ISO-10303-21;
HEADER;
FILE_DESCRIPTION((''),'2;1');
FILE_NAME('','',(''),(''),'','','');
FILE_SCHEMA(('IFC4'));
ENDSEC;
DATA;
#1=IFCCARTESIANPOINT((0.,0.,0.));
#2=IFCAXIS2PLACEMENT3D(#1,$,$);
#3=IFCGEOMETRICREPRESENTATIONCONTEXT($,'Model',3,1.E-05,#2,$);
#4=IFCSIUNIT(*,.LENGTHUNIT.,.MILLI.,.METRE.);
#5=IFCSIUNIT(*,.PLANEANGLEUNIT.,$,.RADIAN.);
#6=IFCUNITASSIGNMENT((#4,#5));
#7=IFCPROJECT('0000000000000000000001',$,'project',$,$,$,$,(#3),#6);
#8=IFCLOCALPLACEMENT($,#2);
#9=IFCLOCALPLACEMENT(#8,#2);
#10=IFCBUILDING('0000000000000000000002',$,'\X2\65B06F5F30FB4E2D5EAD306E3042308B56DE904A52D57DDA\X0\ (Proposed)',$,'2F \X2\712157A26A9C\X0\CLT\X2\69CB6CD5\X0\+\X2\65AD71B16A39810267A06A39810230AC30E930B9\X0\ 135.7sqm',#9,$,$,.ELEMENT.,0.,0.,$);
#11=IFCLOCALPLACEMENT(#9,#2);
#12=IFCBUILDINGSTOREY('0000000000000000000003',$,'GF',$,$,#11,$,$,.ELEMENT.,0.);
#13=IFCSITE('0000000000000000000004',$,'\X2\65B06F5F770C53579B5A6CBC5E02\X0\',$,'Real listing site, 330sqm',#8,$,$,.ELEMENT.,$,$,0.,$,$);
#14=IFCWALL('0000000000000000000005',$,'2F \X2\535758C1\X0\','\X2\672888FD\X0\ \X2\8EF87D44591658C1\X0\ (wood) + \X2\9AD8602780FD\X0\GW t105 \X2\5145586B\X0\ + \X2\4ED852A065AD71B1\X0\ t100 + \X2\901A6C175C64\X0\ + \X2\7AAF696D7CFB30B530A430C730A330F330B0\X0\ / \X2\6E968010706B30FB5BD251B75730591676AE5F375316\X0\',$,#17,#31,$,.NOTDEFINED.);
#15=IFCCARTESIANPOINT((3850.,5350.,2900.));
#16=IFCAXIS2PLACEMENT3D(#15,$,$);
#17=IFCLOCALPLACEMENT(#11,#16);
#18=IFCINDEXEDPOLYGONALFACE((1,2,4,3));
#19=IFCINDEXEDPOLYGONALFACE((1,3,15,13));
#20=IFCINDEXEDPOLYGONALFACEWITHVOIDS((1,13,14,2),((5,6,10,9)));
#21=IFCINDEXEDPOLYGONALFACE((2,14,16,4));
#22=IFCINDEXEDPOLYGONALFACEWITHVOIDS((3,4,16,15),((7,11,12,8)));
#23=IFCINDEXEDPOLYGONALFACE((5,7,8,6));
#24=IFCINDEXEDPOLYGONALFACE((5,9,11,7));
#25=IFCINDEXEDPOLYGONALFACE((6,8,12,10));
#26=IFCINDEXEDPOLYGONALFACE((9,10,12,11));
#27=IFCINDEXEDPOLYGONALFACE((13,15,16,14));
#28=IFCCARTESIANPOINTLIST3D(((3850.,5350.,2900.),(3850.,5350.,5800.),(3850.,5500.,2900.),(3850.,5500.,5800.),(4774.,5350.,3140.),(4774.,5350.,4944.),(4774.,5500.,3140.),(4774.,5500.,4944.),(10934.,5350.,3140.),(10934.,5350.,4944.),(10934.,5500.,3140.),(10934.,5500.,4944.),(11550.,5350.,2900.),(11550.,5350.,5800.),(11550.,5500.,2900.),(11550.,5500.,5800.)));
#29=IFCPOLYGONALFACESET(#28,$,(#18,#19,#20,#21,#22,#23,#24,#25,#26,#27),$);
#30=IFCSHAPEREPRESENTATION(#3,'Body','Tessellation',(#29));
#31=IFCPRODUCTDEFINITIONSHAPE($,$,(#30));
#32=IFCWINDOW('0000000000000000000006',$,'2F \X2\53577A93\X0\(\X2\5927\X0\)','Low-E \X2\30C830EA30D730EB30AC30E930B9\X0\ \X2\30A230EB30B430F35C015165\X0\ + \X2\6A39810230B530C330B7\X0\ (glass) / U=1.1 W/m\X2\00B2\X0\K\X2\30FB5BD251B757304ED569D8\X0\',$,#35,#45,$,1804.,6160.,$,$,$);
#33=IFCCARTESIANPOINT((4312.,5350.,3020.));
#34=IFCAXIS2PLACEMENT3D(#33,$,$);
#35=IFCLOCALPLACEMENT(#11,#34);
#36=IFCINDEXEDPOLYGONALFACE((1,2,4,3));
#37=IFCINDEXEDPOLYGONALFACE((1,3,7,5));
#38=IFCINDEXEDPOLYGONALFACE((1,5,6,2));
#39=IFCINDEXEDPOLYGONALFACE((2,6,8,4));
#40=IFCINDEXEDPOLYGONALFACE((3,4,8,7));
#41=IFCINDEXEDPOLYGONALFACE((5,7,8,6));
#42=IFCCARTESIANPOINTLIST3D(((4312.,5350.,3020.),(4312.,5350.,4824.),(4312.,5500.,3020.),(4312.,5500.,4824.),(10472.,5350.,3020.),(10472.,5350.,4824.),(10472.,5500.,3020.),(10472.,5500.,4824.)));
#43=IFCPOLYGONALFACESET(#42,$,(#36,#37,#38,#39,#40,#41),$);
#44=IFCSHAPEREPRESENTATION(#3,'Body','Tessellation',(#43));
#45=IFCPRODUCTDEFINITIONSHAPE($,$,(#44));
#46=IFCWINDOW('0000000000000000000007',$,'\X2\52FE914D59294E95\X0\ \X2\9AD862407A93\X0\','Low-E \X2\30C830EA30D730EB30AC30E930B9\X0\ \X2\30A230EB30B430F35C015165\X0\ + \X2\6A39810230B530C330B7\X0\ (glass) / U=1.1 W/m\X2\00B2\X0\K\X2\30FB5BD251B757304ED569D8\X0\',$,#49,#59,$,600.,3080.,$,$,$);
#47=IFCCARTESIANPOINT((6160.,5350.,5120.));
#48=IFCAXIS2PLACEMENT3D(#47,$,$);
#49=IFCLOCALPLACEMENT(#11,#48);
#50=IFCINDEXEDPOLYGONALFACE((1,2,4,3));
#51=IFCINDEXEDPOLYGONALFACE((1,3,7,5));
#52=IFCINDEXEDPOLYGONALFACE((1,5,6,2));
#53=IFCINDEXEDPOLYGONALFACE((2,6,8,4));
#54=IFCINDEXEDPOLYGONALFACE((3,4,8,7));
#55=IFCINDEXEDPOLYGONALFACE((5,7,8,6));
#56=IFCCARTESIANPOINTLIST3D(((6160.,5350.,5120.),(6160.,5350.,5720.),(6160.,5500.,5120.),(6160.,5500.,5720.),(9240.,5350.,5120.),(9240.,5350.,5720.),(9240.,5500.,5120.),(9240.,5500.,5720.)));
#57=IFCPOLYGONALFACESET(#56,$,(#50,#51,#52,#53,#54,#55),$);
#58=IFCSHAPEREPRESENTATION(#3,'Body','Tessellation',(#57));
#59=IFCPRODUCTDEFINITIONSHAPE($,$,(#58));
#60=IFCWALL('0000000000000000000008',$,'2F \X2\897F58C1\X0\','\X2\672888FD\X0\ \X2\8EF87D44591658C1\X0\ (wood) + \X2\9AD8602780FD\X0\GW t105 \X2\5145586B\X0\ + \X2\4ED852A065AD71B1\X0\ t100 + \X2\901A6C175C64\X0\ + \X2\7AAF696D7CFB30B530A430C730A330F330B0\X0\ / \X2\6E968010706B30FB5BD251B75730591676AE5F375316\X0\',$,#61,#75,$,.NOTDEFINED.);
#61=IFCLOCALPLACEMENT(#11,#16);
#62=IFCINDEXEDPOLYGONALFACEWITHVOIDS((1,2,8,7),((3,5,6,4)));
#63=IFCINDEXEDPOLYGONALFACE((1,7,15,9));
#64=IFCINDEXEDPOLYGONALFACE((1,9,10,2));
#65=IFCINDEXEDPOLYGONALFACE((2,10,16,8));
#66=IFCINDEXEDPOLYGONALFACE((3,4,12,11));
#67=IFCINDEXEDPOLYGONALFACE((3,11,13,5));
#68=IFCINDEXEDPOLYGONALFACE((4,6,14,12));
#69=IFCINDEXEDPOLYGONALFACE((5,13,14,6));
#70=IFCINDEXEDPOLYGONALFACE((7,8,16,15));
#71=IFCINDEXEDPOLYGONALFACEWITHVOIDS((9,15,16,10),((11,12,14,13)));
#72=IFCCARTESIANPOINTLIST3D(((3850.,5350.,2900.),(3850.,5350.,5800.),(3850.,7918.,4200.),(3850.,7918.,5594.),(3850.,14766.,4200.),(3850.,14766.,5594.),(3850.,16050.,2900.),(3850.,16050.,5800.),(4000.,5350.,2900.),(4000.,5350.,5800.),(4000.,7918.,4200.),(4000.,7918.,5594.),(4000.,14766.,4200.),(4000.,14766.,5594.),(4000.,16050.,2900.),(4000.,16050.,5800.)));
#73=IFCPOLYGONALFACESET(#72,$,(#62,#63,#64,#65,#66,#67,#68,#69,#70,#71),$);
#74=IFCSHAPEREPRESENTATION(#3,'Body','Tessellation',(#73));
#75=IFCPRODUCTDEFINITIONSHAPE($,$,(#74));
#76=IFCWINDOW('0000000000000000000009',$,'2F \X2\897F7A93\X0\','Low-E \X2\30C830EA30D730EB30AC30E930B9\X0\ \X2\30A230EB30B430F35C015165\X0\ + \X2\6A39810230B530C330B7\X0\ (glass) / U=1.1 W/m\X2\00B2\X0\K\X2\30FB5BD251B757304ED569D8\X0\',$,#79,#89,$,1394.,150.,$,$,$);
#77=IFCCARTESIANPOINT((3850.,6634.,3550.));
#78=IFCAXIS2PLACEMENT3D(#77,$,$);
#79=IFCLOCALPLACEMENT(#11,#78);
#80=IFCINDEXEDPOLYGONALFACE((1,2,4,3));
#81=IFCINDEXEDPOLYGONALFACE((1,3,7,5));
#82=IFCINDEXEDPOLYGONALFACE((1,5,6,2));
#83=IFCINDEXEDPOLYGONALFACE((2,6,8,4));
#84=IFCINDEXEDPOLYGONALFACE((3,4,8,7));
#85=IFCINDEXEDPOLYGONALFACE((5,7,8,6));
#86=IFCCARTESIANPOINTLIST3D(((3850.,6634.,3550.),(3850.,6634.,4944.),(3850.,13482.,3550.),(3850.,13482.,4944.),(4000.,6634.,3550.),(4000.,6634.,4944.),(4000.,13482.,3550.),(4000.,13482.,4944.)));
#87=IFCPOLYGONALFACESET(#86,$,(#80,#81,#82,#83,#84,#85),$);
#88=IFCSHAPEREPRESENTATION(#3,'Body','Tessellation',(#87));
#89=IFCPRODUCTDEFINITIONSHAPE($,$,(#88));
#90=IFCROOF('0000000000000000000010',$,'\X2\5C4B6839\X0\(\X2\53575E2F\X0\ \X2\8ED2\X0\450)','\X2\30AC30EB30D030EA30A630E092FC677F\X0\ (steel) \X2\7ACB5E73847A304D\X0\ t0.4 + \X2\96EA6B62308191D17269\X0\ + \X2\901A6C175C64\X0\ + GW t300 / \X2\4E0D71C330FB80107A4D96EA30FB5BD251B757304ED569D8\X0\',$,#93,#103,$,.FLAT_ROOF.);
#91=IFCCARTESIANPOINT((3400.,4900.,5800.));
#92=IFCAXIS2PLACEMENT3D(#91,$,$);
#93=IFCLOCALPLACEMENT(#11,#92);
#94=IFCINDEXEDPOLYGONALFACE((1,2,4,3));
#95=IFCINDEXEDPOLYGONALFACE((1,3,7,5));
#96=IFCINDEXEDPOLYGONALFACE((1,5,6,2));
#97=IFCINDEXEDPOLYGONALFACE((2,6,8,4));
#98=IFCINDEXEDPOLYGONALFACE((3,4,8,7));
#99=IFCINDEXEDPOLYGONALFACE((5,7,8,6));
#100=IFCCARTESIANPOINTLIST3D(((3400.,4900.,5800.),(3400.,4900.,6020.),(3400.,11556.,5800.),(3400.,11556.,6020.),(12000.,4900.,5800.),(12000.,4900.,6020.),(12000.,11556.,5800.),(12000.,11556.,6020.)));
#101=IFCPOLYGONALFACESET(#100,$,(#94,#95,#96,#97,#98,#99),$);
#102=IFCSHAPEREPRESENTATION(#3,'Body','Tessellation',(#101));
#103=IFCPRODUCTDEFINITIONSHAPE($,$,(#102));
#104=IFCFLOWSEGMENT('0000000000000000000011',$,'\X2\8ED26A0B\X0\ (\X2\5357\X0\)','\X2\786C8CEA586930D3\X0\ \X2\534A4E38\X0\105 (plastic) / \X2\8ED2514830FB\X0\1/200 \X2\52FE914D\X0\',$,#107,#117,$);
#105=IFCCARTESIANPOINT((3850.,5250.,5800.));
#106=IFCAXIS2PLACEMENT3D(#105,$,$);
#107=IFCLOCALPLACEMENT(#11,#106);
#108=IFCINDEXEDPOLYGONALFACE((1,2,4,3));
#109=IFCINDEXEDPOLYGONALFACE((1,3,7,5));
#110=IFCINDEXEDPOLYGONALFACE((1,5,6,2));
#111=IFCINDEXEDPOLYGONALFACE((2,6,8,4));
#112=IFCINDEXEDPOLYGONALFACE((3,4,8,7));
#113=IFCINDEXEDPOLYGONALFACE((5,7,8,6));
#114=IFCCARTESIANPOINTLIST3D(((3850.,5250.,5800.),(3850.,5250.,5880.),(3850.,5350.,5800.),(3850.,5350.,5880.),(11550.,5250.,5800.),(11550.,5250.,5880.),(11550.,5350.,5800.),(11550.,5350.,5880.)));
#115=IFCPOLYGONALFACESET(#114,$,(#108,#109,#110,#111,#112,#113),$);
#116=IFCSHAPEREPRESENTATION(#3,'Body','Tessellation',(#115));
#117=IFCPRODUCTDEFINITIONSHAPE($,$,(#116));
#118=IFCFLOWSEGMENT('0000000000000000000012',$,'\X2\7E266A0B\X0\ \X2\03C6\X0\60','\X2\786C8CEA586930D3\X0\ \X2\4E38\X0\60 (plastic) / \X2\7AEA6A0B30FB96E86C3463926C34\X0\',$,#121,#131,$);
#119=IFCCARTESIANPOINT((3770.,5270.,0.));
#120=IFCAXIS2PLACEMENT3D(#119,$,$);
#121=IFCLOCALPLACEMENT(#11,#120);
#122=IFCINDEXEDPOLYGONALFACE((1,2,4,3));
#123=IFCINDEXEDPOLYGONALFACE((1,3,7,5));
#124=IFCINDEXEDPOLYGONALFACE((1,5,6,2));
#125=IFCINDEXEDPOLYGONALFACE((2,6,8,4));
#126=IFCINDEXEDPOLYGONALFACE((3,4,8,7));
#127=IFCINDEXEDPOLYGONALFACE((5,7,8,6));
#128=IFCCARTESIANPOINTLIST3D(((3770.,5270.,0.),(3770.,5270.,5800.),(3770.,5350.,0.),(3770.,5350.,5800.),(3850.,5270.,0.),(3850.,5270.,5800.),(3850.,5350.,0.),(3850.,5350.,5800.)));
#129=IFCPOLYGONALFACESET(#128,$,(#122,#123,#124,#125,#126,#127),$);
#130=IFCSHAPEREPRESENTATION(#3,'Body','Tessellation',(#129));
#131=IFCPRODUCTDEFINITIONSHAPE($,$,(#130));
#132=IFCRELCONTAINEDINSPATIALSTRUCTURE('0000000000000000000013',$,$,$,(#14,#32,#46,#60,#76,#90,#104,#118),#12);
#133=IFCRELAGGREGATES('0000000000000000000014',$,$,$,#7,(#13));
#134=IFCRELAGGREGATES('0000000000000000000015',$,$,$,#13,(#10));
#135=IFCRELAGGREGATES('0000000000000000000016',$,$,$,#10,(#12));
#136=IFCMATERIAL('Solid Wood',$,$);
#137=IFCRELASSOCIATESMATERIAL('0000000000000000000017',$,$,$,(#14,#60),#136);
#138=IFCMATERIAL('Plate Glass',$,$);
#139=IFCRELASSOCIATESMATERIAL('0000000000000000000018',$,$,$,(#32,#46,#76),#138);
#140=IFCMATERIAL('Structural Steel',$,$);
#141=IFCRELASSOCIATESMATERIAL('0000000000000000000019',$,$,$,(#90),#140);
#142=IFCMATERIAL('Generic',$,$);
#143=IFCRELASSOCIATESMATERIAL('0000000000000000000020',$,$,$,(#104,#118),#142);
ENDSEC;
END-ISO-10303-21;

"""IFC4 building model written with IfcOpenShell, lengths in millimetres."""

from ifc_helpers import new_model, si_unit, frame, frame_2d, origin, place, context, project, spatial, rectangle, extrude, material, element, fill, save


model = new_model("IFC4")

# Units and contexts
model_context = context("Model", 3, precision=1e-05, world=origin())
ifc_project = project(units=[si_unit("LENGTHUNIT", "METRE", prefix="MILLI"), si_unit("PLANEANGLEUNIT", "RADIAN")], contexts=[model_context])

# Site, building, storey
site_placement = place(None, origin())
site = spatial("IfcSite", under=ifc_project, at=site_placement, Name="新潟県南魚沼市", ObjectType="Real listing site, 330sqm", CompositionType="ELEMENT", RefElevation=0.0)
building_placement = place(site_placement, origin())
building = spatial("IfcBuilding", under=site, at=building_placement, Name="新潟・中庭のある回遊動線 (Proposed)", ObjectType="2F 無垢檜CLT構法+断熱樹脂枠樹脂ガラス 135.7sqm", CompositionType="ELEMENT", ElevationOfRefHeight=0.0, ElevationOfTerrain=0.0)
storey_placement = place(building_placement, origin())
storey = spatial("IfcBuildingStorey", under=building, at=storey_placement, Name="GF", CompositionType="ELEMENT", Elevation=0.0)

# Shared definitions
ifc_material_1 = material(Name="Solid Wood")

# Shared definitions
ifc_material_2 = material(Name="Plate Glass")

# Wall, openings, windows
wall_1_placement = place(storey_placement, frame((3850.0, 5350.0, 2900.0)))
wall_1 = element("IfcWall", 1, at=wall_1_placement, inside=storey, material=ifc_material_1, Name="2F 南壁", Description="木製 軸組外壁 (wood) + 高性能GW t105 充填 + 付加断熱 t100 + 通気層 + 窯業系サイディング / 準耐火・寒冷地外皮強化", PredefinedType="NOTDEFINED", context=model_context, shape_type="SweptSolid", body=[
    extrude(rectangle(XDim=7700.0, YDim=150.0, at=frame_2d((3850.0, 75.0))), frame((3850.0, 5350.0, 2900.0)), (0.0, 0.0, 1.0), 2900.0),
])
opening_1_placement = place(storey_placement, frame((4312.0, 5350.0, 3020.0)))
opening_1 = element("IfcOpeningElement", 2, at=opening_1_placement, cuts=wall_1, PredefinedType="NOTDEFINED", context=model_context, shape_type="SweptSolid", body=[
    extrude(rectangle(XDim=6160.0, YDim=150.0, at=frame_2d((3080.0, 75.0))), frame((4312.0, 5350.0, 3020.0)), (0.0, 0.0, 1.0), 1804.0),
])
opening_2_placement = place(storey_placement, frame((6160.0, 5350.0, 5120.0)))
opening_2 = element("IfcOpeningElement", 3, at=opening_2_placement, cuts=wall_1, PredefinedType="NOTDEFINED", context=model_context, shape_type="SweptSolid", body=[
    extrude(rectangle(XDim=3080.0, YDim=150.0, at=frame_2d((1540.0, 75.0))), frame((6160.0, 5350.0, 5120.0)), (0.0, 0.0, 1.0), 600.0),
])
window_1_placement = place(storey_placement, frame((4312.0, 5350.0, 3020.0)))
window_1 = element("IfcWindow", 4, at=window_1_placement, inside=storey, material=ifc_material_2, Name="2F 南窓(大)", Description="Low-E トリプルガラス アルゴン封入 + 樹脂サッシ (glass) / U=1.1 W/m²K・寒冷地仕様", OverallHeight=1804.0, OverallWidth=6160.0, context=model_context, shape_type="SweptSolid", body=[
    extrude(rectangle(XDim=6160.0, YDim=150.0, at=frame_2d((3080.0, 75.0))), frame((4312.0, 5350.0, 3020.0)), (0.0, 0.0, 1.0), 1804.0),
])
fill(opening_1, window_1)
window_2_placement = place(storey_placement, frame((6160.0, 5350.0, 5120.0)))
window_2 = element("IfcWindow", 5, at=window_2_placement, inside=storey, material=ifc_material_2, Name="勾配天井 高所窓", Description="Low-E トリプルガラス アルゴン封入 + 樹脂サッシ (glass) / U=1.1 W/m²K・寒冷地仕様", OverallHeight=600.0, OverallWidth=3080.0, context=model_context, shape_type="SweptSolid", body=[
    extrude(rectangle(XDim=3080.0, YDim=150.0, at=frame_2d((1540.0, 75.0))), frame((6160.0, 5350.0, 5120.0)), (0.0, 0.0, 1.0), 600.0),
])
fill(opening_2, window_2)

# Wall, opening, window
wall_2_placement = place(storey_placement, frame((3850.0, 5350.0, 2900.0)))
wall_2 = element("IfcWall", 6, at=wall_2_placement, inside=storey, material=ifc_material_1, Name="2F 西壁", Description="木製 軸組外壁 (wood) + 高性能GW t105 充填 + 付加断熱 t100 + 通気層 + 窯業系サイディング / 準耐火・寒冷地外皮強化", PredefinedType="NOTDEFINED", context=model_context, shape_type="SweptSolid", body=[
    extrude(rectangle(XDim=150.0, YDim=10700.0, at=frame_2d((75.0, 5350.0))), frame((3850.0, 5350.0, 2900.0)), (0.0, 0.0, 1.0), 2900.0),
])
opening_3_placement = place(storey_placement, frame((3850.0, 6634.0, 3550.0)))
opening_3 = element("IfcOpeningElement", 7, at=opening_3_placement, cuts=wall_2, PredefinedType="NOTDEFINED", context=model_context, shape_type="SweptSolid", body=[
    extrude(rectangle(XDim=150.0, YDim=6848.0, at=frame_2d((75.0, 3424.0))), frame((3850.0, 6634.0, 3550.0)), (0.0, 0.0, 1.0), 1394.0),
])
window_3_placement = place(storey_placement, frame((3850.0, 6634.0, 3550.0)))
window_3 = element("IfcWindow", 8, at=window_3_placement, inside=storey, material=ifc_material_2, Name="2F 西窓", Description="Low-E トリプルガラス アルゴン封入 + 樹脂サッシ (glass) / U=1.1 W/m²K・寒冷地仕様", OverallHeight=1394.0, OverallWidth=150.0, context=model_context, shape_type="SweptSolid", body=[
    extrude(rectangle(XDim=150.0, YDim=6848.0, at=frame_2d((75.0, 3424.0))), frame((3850.0, 6634.0, 3550.0)), (0.0, 0.0, 1.0), 1394.0),
])
fill(opening_3, window_3)

# Roof
ifc_material_3 = material(Name="Structural Steel")
for number, where, name in (
    (9, (3400.0, 4900.0, 5800.0), "屋根(南帯 軒450)"),
):
    element("IfcRoof", number, at=place(storey_placement, frame(where)), inside=storey, material=ifc_material_3, Name=name, Description="ガルバリウム鋼板 (steel) 立平葺き t0.4 + 雪止め金物 + 通気層 + GW t300 / 不燃・耐積雪・寒冷地仕様", PredefinedType="FLAT_ROOF", context=model_context, shape_type="SweptSolid", body=[
        extrude(rectangle(XDim=8600.0, YDim=6656.0, at=frame_2d((4300.0, 3328.0))), frame((3400.0, 4900.0, 5800.0)), (0.0, 0.0, 1.0), 220.0),
    ])

# Flow segments
ifc_material_4 = material(Name="Generic")
flow_segment_1_placement = place(storey_placement, frame((3850.0, 5250.0, 5800.0)))
element("IfcFlowSegment", 10, at=flow_segment_1_placement, inside=storey, material=ifc_material_4, Name="軒樋 (南)", Description="硬質塩ビ 半丸105 (plastic) / 軒先・1/200 勾配", context=model_context, shape_type="SweptSolid", body=[
    extrude(rectangle(XDim=7700.0, YDim=100.0, at=frame_2d((3850.0, 50.0))), frame((3850.0, 5250.0, 5800.0)), (0.0, 0.0, 1.0), 80.0),
])
flow_segment_2_placement = place(storey_placement, frame((3770.0, 5270.0, 0.0)))
element("IfcFlowSegment", 11, at=flow_segment_2_placement, inside=storey, material=ifc_material_4, Name="縦樋 φ60", Description="硬質塩ビ 丸60 (plastic) / 竪樋・雨水排水", context=model_context, shape_type="SweptSolid", body=[
    extrude(rectangle(XDim=80.0, YDim=80.0, at=frame_2d((40.0, 40.0))), frame((3770.0, 5270.0, 0.0)), (0.0, 0.0, 1.0), 5800.0),
])

save(model, "model.ifc")
